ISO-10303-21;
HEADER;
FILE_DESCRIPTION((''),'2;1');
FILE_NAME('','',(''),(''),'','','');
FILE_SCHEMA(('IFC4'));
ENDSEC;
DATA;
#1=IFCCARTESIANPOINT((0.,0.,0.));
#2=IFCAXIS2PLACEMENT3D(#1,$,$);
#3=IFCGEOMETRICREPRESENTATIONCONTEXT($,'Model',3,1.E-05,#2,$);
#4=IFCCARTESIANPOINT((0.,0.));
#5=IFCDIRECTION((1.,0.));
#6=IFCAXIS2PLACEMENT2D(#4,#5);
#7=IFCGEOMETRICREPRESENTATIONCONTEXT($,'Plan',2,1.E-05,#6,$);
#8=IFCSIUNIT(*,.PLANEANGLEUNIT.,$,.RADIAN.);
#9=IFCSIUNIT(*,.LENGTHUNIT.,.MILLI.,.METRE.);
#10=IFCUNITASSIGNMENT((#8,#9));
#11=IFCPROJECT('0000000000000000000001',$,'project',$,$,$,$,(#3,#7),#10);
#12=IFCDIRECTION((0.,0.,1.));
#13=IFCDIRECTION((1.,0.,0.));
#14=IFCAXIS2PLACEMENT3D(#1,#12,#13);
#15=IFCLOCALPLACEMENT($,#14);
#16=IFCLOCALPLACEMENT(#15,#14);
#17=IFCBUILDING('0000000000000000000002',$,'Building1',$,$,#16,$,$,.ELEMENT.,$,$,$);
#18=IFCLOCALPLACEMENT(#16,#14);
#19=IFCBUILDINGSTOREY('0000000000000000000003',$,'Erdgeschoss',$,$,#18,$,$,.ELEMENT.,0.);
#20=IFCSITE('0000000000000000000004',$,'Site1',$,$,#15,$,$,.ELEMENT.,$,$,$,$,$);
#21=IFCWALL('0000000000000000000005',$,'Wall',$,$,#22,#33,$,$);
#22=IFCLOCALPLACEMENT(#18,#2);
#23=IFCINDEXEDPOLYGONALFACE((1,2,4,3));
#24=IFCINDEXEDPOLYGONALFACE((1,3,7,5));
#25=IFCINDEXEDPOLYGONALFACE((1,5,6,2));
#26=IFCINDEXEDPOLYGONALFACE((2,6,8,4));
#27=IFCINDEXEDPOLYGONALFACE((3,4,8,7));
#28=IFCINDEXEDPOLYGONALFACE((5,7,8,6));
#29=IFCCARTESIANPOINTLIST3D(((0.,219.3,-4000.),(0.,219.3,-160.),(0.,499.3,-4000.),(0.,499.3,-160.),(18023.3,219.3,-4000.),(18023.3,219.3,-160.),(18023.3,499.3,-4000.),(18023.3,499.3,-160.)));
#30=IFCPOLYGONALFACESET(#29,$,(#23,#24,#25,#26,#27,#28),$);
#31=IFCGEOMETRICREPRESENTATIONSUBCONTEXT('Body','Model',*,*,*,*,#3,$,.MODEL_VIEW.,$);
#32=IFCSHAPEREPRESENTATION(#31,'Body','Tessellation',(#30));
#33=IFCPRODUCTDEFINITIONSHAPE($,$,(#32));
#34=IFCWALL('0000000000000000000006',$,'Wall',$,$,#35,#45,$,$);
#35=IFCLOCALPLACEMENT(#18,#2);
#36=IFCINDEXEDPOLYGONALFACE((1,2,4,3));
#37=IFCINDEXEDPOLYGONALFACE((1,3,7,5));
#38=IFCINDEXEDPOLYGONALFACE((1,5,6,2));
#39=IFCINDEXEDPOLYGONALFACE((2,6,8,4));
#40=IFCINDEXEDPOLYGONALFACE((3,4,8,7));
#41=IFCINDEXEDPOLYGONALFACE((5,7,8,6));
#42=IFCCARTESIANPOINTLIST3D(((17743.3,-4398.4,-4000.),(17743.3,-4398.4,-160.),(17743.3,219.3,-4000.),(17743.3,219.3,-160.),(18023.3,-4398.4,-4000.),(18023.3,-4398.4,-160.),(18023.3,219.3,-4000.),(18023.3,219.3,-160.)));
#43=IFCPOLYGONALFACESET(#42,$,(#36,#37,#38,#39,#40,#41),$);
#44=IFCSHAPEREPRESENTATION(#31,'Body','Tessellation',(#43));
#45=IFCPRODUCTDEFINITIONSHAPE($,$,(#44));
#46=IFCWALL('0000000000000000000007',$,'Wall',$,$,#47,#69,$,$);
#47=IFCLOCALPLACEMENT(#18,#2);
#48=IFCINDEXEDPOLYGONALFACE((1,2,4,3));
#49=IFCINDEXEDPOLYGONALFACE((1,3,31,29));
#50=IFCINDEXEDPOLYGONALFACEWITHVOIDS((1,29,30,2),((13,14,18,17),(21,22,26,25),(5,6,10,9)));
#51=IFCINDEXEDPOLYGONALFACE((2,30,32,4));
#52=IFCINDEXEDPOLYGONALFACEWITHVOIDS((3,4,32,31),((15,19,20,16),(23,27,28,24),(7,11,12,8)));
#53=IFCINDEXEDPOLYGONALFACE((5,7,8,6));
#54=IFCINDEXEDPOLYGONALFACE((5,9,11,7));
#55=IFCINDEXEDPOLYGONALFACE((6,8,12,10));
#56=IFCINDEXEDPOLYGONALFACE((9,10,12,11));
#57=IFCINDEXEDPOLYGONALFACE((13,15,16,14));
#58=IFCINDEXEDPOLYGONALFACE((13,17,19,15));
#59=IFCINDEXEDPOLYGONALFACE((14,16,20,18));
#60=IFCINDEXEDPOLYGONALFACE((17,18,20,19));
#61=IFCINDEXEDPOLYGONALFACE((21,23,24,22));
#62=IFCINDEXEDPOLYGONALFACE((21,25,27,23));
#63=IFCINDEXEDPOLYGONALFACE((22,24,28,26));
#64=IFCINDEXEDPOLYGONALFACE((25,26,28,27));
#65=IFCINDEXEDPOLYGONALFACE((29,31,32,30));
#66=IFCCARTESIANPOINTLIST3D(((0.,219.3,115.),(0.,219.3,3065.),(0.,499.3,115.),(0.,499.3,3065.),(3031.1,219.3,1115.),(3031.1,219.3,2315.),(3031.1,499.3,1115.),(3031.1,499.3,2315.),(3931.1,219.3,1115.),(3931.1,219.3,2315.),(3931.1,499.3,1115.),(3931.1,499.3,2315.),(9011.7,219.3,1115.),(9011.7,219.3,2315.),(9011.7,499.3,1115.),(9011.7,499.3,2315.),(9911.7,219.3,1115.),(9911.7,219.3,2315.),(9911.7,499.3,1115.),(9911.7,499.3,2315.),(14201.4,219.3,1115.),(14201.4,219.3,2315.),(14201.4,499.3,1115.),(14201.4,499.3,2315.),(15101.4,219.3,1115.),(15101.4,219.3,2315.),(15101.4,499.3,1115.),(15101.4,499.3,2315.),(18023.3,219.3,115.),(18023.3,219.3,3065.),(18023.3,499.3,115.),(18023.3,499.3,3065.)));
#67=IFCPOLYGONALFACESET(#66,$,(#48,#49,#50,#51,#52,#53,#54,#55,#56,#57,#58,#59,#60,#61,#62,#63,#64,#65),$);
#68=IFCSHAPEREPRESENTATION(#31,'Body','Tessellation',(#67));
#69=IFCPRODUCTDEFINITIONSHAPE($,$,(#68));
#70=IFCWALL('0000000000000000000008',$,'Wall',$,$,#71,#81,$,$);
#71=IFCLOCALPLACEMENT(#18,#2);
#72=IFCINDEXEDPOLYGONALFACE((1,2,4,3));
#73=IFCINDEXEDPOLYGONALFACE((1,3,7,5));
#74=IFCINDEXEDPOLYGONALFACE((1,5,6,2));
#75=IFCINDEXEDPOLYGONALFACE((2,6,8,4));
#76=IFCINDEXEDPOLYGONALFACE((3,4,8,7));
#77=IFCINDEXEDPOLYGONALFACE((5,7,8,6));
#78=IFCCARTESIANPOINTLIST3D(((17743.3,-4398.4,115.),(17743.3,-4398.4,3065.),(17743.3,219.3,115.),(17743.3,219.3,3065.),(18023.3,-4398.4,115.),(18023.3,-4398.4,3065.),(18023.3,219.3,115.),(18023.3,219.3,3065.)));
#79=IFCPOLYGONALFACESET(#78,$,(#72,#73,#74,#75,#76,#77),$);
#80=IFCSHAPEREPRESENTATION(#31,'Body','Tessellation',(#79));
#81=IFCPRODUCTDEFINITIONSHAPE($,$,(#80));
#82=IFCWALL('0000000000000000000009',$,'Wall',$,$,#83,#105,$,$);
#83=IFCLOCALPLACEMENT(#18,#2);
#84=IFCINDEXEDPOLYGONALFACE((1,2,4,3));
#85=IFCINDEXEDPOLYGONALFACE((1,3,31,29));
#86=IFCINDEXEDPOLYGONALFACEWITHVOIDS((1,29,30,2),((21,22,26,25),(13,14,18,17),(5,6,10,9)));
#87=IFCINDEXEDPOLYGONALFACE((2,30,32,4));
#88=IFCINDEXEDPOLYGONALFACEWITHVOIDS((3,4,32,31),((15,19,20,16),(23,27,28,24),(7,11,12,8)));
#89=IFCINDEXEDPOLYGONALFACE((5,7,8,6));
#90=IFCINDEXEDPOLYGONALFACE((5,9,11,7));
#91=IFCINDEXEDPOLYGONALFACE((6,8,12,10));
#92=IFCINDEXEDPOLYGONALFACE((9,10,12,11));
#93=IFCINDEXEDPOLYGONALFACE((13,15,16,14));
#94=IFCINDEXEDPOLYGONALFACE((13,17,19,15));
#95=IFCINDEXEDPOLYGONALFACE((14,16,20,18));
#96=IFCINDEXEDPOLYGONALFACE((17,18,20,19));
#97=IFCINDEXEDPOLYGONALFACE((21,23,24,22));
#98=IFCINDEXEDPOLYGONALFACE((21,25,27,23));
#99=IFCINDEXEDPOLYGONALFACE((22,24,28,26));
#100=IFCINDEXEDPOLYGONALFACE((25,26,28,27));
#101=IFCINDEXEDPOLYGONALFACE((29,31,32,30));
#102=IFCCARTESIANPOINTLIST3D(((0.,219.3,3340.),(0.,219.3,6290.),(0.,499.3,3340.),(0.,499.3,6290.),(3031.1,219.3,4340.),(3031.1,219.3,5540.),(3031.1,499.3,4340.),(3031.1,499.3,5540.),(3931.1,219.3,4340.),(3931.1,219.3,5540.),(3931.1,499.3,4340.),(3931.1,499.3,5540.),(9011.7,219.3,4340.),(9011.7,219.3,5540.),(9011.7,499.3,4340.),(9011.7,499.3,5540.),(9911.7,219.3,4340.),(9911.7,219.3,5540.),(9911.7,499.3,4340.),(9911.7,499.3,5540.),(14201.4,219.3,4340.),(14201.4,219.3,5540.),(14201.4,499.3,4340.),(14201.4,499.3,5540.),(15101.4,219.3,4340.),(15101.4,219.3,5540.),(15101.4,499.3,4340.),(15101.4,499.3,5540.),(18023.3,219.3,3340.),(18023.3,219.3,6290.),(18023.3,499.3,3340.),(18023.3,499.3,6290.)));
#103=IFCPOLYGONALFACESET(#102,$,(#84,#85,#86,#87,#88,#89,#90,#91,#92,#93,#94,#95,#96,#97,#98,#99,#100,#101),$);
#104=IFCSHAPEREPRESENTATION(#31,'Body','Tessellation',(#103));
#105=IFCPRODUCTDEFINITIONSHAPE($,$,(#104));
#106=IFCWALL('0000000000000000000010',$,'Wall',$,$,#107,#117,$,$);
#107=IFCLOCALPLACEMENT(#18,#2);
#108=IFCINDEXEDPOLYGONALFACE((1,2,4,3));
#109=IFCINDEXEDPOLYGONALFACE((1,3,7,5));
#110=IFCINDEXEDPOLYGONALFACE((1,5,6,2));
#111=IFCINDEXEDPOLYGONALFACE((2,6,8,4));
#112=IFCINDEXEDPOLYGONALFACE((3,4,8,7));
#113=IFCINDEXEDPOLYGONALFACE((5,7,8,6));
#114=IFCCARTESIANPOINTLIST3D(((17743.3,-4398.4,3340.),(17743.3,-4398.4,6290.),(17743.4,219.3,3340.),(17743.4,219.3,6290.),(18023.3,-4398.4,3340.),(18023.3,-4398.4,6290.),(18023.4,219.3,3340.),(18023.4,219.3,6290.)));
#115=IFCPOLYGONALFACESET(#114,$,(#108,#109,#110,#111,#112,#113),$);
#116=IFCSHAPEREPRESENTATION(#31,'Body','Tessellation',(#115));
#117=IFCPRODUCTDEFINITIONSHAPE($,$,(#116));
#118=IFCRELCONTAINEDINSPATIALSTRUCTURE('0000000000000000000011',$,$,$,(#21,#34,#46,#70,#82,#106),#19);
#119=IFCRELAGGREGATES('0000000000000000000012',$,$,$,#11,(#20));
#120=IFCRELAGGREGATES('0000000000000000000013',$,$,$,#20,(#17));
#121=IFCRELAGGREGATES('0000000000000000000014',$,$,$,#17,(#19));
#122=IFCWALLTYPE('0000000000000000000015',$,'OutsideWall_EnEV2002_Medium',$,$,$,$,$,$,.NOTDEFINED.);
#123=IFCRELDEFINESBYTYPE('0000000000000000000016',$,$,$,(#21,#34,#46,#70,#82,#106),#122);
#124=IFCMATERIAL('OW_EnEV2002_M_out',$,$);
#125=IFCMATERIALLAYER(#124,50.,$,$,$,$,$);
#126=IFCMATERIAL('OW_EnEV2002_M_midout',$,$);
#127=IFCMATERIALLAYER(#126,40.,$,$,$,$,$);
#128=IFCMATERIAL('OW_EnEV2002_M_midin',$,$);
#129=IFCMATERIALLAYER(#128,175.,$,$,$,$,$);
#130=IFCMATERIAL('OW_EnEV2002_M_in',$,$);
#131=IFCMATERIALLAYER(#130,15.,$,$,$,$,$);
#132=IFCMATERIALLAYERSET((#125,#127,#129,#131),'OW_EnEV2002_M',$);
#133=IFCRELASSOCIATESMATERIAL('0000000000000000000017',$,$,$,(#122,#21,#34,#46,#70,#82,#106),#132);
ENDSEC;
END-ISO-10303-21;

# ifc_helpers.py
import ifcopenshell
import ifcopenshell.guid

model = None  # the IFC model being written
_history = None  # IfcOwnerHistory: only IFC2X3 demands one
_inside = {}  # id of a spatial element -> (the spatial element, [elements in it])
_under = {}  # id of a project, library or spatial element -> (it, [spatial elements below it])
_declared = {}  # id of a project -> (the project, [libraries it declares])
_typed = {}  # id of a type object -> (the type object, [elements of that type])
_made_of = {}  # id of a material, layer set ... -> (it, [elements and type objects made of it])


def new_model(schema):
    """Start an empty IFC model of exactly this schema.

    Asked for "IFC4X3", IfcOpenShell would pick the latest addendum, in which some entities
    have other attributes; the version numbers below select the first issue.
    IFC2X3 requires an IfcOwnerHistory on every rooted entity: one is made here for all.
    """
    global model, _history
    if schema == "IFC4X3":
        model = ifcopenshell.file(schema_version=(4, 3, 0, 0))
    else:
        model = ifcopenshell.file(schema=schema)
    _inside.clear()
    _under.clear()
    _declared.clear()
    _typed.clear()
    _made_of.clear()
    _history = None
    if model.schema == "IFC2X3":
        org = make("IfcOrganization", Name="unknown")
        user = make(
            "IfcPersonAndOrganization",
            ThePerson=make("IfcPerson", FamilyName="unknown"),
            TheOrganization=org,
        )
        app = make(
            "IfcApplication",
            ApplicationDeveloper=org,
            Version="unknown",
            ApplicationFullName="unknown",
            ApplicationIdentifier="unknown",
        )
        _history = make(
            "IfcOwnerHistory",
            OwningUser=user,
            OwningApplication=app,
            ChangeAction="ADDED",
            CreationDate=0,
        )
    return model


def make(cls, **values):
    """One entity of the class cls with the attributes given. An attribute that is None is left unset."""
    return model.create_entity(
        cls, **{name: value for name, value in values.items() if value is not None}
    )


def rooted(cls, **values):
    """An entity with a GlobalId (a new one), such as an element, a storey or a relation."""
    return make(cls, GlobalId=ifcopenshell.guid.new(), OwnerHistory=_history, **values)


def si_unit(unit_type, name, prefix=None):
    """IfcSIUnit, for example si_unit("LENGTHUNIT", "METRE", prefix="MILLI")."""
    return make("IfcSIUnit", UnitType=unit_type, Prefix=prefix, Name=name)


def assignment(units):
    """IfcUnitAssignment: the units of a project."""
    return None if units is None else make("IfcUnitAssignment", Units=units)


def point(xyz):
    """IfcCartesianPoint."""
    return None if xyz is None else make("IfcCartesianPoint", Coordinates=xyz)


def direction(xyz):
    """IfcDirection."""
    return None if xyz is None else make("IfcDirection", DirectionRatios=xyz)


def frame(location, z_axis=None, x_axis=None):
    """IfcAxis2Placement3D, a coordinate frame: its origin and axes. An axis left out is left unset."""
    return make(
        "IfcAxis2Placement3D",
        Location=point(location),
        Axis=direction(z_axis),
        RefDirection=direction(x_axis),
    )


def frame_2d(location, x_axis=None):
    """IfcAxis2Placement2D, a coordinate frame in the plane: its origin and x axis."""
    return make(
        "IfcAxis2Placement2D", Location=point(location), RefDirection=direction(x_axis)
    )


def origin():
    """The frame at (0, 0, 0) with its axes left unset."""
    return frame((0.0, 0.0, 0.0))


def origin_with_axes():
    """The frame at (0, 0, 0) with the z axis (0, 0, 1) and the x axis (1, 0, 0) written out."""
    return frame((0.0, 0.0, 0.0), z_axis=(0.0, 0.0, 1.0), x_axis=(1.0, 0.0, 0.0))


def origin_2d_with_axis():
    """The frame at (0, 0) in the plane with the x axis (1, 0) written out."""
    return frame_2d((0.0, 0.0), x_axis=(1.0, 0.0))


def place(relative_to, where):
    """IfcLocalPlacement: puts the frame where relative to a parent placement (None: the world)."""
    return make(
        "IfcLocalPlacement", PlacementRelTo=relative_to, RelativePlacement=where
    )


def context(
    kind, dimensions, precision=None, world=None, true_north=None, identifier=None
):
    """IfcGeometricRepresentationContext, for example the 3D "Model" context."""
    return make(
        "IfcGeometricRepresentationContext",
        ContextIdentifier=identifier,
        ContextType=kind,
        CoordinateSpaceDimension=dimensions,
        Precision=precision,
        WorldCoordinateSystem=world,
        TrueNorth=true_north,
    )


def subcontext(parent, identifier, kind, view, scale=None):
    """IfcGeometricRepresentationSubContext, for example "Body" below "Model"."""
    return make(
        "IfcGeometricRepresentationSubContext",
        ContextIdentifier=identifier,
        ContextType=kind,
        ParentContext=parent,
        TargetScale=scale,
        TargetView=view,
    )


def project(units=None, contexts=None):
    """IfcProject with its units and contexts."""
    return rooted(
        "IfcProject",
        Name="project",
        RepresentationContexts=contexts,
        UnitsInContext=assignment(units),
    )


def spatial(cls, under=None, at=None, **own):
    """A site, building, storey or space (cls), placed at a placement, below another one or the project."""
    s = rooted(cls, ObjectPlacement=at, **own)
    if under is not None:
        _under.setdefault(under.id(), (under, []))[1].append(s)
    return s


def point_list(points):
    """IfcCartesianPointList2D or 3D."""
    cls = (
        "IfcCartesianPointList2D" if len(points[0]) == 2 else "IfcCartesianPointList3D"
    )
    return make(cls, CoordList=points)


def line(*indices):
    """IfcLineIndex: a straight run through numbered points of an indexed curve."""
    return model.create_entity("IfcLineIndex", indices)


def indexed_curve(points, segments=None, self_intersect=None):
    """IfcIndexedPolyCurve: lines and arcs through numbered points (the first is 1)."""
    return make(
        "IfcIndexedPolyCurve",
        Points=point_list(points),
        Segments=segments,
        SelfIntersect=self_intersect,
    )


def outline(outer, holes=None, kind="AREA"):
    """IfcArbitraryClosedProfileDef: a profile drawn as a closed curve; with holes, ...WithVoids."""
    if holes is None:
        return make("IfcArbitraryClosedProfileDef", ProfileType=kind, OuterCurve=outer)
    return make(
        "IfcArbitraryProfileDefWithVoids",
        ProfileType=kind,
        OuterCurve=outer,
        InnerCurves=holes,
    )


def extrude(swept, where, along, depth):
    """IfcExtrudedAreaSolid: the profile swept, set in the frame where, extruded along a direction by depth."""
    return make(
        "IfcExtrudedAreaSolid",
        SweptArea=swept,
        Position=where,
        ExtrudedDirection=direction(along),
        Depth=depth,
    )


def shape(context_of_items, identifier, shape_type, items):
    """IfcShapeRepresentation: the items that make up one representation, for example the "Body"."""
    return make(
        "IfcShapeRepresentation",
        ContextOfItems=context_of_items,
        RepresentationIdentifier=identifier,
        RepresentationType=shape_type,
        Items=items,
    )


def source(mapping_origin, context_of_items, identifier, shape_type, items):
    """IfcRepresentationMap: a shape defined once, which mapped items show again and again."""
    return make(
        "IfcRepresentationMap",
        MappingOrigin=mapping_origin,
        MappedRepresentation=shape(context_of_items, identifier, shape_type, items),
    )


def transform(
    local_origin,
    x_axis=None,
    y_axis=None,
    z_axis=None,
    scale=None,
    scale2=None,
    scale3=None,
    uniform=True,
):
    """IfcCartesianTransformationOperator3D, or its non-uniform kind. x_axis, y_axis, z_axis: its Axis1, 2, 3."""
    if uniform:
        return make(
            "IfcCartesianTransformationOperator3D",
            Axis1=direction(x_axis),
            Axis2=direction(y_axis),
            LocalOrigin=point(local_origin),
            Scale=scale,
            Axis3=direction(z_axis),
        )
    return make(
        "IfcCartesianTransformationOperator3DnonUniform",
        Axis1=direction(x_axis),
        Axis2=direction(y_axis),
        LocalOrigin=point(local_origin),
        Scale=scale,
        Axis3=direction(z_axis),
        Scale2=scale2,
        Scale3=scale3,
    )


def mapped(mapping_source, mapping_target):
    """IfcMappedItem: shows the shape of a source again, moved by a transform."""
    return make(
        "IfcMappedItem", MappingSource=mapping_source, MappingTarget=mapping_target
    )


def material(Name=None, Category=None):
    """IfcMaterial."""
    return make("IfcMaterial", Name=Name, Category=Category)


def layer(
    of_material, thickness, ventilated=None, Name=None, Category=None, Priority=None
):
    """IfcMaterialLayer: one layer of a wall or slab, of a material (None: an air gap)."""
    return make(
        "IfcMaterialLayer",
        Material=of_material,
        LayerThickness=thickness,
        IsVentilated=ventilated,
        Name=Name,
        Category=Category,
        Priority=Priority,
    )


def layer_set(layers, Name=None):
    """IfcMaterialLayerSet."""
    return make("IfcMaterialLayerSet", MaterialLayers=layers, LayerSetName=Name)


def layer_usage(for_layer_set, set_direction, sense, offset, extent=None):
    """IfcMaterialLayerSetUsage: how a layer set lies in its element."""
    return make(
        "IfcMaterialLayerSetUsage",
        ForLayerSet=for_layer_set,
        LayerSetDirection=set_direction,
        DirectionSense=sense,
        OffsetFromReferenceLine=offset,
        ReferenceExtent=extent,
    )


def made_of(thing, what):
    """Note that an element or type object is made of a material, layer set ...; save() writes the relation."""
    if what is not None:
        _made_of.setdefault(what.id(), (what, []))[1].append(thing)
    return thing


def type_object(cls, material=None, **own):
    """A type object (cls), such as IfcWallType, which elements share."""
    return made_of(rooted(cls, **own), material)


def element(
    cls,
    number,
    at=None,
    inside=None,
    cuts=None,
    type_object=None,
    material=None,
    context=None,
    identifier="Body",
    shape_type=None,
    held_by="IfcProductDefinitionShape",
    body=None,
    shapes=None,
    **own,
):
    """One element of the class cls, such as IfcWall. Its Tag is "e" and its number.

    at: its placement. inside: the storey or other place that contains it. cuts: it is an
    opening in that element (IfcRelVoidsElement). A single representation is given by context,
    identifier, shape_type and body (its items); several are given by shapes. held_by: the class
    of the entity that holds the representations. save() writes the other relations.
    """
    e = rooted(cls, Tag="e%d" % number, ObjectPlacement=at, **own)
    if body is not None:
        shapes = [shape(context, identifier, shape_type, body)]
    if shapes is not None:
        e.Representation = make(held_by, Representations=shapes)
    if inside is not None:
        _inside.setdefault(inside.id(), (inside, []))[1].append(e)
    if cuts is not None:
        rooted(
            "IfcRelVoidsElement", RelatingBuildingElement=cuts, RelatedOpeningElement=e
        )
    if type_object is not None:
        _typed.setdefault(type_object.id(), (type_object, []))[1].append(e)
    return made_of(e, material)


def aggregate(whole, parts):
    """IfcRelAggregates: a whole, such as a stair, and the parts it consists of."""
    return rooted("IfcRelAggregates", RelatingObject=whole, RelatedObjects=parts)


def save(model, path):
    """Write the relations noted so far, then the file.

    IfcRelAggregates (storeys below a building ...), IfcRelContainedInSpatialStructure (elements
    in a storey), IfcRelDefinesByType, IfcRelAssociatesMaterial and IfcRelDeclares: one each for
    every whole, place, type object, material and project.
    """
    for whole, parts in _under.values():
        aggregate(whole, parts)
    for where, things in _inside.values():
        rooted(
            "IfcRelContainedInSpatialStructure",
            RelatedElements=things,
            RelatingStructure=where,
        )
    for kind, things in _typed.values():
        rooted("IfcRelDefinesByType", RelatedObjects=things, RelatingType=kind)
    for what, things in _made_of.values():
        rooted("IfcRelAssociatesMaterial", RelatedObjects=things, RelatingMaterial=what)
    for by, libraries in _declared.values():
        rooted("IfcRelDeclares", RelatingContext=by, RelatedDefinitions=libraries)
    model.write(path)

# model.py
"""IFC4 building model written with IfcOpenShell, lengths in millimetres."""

from ifc_helpers import new_model, si_unit, frame, origin, origin_with_axes, origin_2d_with_axis, place, context, subcontext, project, spatial, line, indexed_curve, outline, extrude, source, transform, mapped, material, layer, layer_set, layer_usage, type_object, element, save


model = new_model("IFC4")

# Units and contexts
model_context = context("Model", 3, precision=1e-05, world=origin())
plan_context = context("Plan", 2, precision=1e-05, world=origin_2d_with_axis())
body_context = subcontext(model_context, "Body", "Model", "MODEL_VIEW")
ifc_project = project(units=[si_unit("PLANEANGLEUNIT", "RADIAN"), si_unit("LENGTHUNIT", "METRE", prefix="MILLI")], contexts=[model_context, plan_context])

# Site, building, storey
site_placement = place(None, origin_with_axes())
site = spatial("IfcSite", under=ifc_project, at=site_placement, Name="Site1", CompositionType="ELEMENT")
building_placement = place(site_placement, origin_with_axes())
building = spatial("IfcBuilding", under=site, at=building_placement, Name="Building1", CompositionType="ELEMENT")
storey_placement = place(building_placement, origin_with_axes())
storey = spatial("IfcBuildingStorey", under=building, at=storey_placement, Name="Erdgeschoss", CompositionType="ELEMENT", Elevation=0.0)

# Walls
ifc_material_1 = material(Name="OW_EnEV2002_M_out")
ifc_layer_1 = layer(ifc_material_1, 50.0)
ifc_material_2 = material(Name="OW_EnEV2002_M_midout")
ifc_layer_2 = layer(ifc_material_2, 40.0)
ifc_material_3 = material(Name="OW_EnEV2002_M_midin")
ifc_layer_3 = layer(ifc_material_3, 175.0)
ifc_material_4 = material(Name="OW_EnEV2002_M_in")
ifc_layer_4 = layer(ifc_material_4, 15.0)
ifc_layer_set = layer_set([ifc_layer_1, ifc_layer_2, ifc_layer_3, ifc_layer_4], Name="OW_EnEV2002_M")
ifc_layer_usage_1 = layer_usage(ifc_layer_set, "AXIS2", "POSITIVE", 0.0)
wall_type = type_object("IfcWallType", Name="OutsideWall_EnEV2002_Medium", PredefinedType="NOTDEFINED", material=ifc_layer_set)
wall_1_placement = place(storey_placement, frame((18023.3, 499.3, -4000.0), z_axis=(0.0, 0.0, 1.0), x_axis=(-1.0, 0.0, 0.0)))
element("IfcWall", 1, at=wall_1_placement, inside=storey, type_object=wall_type, material=ifc_layer_usage_1, Name="Wall", context=body_context, shape_type="SweptSolid", body=[
    extrude(outline(indexed_curve([(0.0, 0.0), (0.0, 280.0), (18023.3, 280.0), (18023.3, 0.0), (0.0, 0.0)], self_intersect=False)), origin_with_axes(), (0.0, 0.0, 1.0), 3840.0),
])
ifc_layer_usage_2 = layer_usage(ifc_layer_set, "AXIS2", "POSITIVE", 0.0)
wall_2_placement = place(storey_placement, frame((18023.3, -4398.4, -4000.0), z_axis=(0.0, 0.0, 1.0), x_axis=(0.0, 1.0, 0.0)))
element("IfcWall", 2, at=wall_2_placement, inside=storey, type_object=wall_type, material=ifc_layer_usage_2, Name="Wall", context=body_context, shape_type="SweptSolid", body=[
    extrude(outline(indexed_curve([(0.0, 0.0), (0.0, 280.0), (4617.6, 280.0), (4617.6, 0.0), (0.0, 0.0)], self_intersect=False)), origin_with_axes(), (0.0, 0.0, 1.0), 3840.0),
])

# Wall, openings
ifc_layer_usage_3 = layer_usage(ifc_layer_set, "AXIS2", "POSITIVE", 0.0)
wall_3_placement = place(storey_placement, frame((18023.3, 499.3, 115.0), z_axis=(0.0, 0.0, 1.0), x_axis=(-1.0, 0.0, 0.0)))
wall_3 = element("IfcWall", 3, at=wall_3_placement, inside=storey, type_object=wall_type, material=ifc_layer_usage_3, Name="Wall", context=body_context, shape_type="SweptSolid", body=[
    extrude(outline(indexed_curve([(0.0, 0.0), (0.0, 280.0), (18023.3, 280.0), (18023.3, 0.0), (0.0, 0.0)], self_intersect=False)), origin_with_axes(), (0.0, 0.0, 1.0), 2950.0),
])
shared_shape_1 = source(origin_with_axes(), body_context, "Body", "SweptSolid", [
    extrude(outline(indexed_curve([(0.0, 0.0), (900.0, 0.0), (900.0, 1200.0), (0.0, 1200.0)], segments=[line(1, 2, 3, 4, 1)])), frame((0.0, -600.0, 0.0), z_axis=(0.0, -1.0, 0.0), x_axis=(1.0, 0.0, 0.0)), (0.0, 0.0, -1.0), 1200.0),
])
opening_1_placement = place(wall_3_placement, frame((2921.9, 0.0, 1000.0), z_axis=(0.0, 0.0, 1.0), x_axis=(1.0, 0.0, 0.0)))
element("IfcOpeningElement", 4, at=opening_1_placement, cuts=wall_3, PredefinedType="OPENING", context=body_context, shape_type="MappedRepresentation", body=[
    mapped(shared_shape_1, transform((0.0, 0.0, 0.0), x_axis=(1.0, 0.0, 0.0), y_axis=(0.0, 1.0, 0.0), z_axis=(0.0, 0.0, 1.0), scale=1.0)),
])
opening_2_placement = place(wall_3_placement, frame((8111.7, 0.0, 1000.0), z_axis=(0.0, 0.0, 1.0), x_axis=(1.0, 0.0, 0.0)))
element("IfcOpeningElement", 5, at=opening_2_placement, cuts=wall_3, PredefinedType="OPENING", context=body_context, shape_type="MappedRepresentation", body=[
    mapped(shared_shape_1, transform((0.0, 0.0, 0.0), x_axis=(1.0, 0.0, 0.0), y_axis=(0.0, 1.0, 0.0), z_axis=(0.0, 0.0, 1.0), scale=1.0)),
])
opening_3_placement = place(wall_3_placement, frame((14092.2, 0.0, 1000.0), z_axis=(0.0, 0.0, 1.0), x_axis=(1.0, 0.0, 0.0)))
element("IfcOpeningElement", 6, at=opening_3_placement, cuts=wall_3, PredefinedType="OPENING", context=body_context, shape_type="MappedRepresentation", body=[
    mapped(shared_shape_1, transform((0.0, 0.0, 0.0), x_axis=(1.0, 0.0, 0.0), y_axis=(0.0, 1.0, 0.0), z_axis=(0.0, 0.0, 1.0), scale=1.0)),
])

# Wall
ifc_layer_usage_4 = layer_usage(ifc_layer_set, "AXIS2", "POSITIVE", 0.0)
wall_4_placement = place(storey_placement, frame((18023.3, -4398.4, 115.0), z_axis=(0.0, 0.0, 1.0), x_axis=(0.0, 1.0, 0.0)))
element("IfcWall", 7, at=wall_4_placement, inside=storey, type_object=wall_type, material=ifc_layer_usage_4, Name="Wall", context=body_context, shape_type="SweptSolid", body=[
    extrude(outline(indexed_curve([(0.0, 0.0), (0.0, 280.0), (4617.6, 280.0), (4617.6, 0.0), (0.0, 0.0)], self_intersect=False)), origin_with_axes(), (0.0, 0.0, 1.0), 2950.0),
])

# Wall, openings
ifc_layer_usage_5 = layer_usage(ifc_layer_set, "AXIS2", "POSITIVE", 0.0)
wall_5_placement = place(storey_placement, frame((18023.3, 499.3, 3340.0), z_axis=(0.0, 0.0, 1.0), x_axis=(-1.0, 0.0, 0.0)))
wall_5 = element("IfcWall", 8, at=wall_5_placement, inside=storey, type_object=wall_type, material=ifc_layer_usage_5, Name="Wall", context=body_context, shape_type="SweptSolid", body=[
    extrude(outline(indexed_curve([(0.0, 0.0), (0.0, 280.0), (18023.3, 280.0), (18023.3, 0.0), (0.0, 0.0)], self_intersect=False)), origin_with_axes(), (0.0, 0.0, 1.0), 2950.0),
])
opening_4_placement = place(wall_5_placement, frame((14092.2, 0.0, 1000.0), z_axis=(0.0, 0.0, 1.0), x_axis=(1.0, 0.0, 0.0)))
element("IfcOpeningElement", 9, at=opening_4_placement, cuts=wall_5, PredefinedType="OPENING", context=body_context, shape_type="MappedRepresentation", body=[
    mapped(shared_shape_1, transform((0.0, 0.0, 0.0), x_axis=(1.0, 0.0, 0.0), y_axis=(0.0, 1.0, 0.0), z_axis=(0.0, 0.0, 1.0), scale=1.0)),
])
opening_5_placement = place(wall_5_placement, frame((8111.7, 0.0, 1000.0), z_axis=(0.0, 0.0, 1.0), x_axis=(1.0, 0.0, 0.0)))
element("IfcOpeningElement", 10, at=opening_5_placement, cuts=wall_5, PredefinedType="OPENING", context=body_context, shape_type="MappedRepresentation", body=[
    mapped(shared_shape_1, transform((0.0, 0.0, 0.0), x_axis=(1.0, 0.0, 0.0), y_axis=(0.0, 1.0, 0.0), z_axis=(0.0, 0.0, 1.0), scale=1.0)),
])
opening_6_placement = place(wall_5_placement, frame((2921.9, 0.0, 1000.0), z_axis=(0.0, 0.0, 1.0), x_axis=(1.0, 0.0, 0.0)))
element("IfcOpeningElement", 11, at=opening_6_placement, cuts=wall_5, PredefinedType="OPENING", context=body_context, shape_type="MappedRepresentation", body=[
    mapped(shared_shape_1, transform((0.0, 0.0, 0.0), x_axis=(1.0, 0.0, 0.0), y_axis=(0.0, 1.0, 0.0), z_axis=(0.0, 0.0, 1.0), scale=1.0)),
])

# Wall
ifc_layer_usage_6 = layer_usage(ifc_layer_set, "AXIS2", "POSITIVE", 0.0)
wall_6_placement = place(storey_placement, frame((18023.3, -4398.4, 3340.0), z_axis=(0.0, 0.0, 1.0), x_axis=(0.000001, 1.0, 0.0)))
element("IfcWall", 12, at=wall_6_placement, inside=storey, type_object=wall_type, material=ifc_layer_usage_6, Name="Wall", context=body_context, shape_type="SweptSolid", body=[
    extrude(outline(indexed_curve([(0.0, 0.0), (0.0, 280.0), (4617.6, 280.0), (4617.6, 0.0), (0.0, 0.0)], self_intersect=False)), origin_with_axes(), (0.0, 0.0, 1.0), 2950.0),
])

save(model, "model.ifc")
